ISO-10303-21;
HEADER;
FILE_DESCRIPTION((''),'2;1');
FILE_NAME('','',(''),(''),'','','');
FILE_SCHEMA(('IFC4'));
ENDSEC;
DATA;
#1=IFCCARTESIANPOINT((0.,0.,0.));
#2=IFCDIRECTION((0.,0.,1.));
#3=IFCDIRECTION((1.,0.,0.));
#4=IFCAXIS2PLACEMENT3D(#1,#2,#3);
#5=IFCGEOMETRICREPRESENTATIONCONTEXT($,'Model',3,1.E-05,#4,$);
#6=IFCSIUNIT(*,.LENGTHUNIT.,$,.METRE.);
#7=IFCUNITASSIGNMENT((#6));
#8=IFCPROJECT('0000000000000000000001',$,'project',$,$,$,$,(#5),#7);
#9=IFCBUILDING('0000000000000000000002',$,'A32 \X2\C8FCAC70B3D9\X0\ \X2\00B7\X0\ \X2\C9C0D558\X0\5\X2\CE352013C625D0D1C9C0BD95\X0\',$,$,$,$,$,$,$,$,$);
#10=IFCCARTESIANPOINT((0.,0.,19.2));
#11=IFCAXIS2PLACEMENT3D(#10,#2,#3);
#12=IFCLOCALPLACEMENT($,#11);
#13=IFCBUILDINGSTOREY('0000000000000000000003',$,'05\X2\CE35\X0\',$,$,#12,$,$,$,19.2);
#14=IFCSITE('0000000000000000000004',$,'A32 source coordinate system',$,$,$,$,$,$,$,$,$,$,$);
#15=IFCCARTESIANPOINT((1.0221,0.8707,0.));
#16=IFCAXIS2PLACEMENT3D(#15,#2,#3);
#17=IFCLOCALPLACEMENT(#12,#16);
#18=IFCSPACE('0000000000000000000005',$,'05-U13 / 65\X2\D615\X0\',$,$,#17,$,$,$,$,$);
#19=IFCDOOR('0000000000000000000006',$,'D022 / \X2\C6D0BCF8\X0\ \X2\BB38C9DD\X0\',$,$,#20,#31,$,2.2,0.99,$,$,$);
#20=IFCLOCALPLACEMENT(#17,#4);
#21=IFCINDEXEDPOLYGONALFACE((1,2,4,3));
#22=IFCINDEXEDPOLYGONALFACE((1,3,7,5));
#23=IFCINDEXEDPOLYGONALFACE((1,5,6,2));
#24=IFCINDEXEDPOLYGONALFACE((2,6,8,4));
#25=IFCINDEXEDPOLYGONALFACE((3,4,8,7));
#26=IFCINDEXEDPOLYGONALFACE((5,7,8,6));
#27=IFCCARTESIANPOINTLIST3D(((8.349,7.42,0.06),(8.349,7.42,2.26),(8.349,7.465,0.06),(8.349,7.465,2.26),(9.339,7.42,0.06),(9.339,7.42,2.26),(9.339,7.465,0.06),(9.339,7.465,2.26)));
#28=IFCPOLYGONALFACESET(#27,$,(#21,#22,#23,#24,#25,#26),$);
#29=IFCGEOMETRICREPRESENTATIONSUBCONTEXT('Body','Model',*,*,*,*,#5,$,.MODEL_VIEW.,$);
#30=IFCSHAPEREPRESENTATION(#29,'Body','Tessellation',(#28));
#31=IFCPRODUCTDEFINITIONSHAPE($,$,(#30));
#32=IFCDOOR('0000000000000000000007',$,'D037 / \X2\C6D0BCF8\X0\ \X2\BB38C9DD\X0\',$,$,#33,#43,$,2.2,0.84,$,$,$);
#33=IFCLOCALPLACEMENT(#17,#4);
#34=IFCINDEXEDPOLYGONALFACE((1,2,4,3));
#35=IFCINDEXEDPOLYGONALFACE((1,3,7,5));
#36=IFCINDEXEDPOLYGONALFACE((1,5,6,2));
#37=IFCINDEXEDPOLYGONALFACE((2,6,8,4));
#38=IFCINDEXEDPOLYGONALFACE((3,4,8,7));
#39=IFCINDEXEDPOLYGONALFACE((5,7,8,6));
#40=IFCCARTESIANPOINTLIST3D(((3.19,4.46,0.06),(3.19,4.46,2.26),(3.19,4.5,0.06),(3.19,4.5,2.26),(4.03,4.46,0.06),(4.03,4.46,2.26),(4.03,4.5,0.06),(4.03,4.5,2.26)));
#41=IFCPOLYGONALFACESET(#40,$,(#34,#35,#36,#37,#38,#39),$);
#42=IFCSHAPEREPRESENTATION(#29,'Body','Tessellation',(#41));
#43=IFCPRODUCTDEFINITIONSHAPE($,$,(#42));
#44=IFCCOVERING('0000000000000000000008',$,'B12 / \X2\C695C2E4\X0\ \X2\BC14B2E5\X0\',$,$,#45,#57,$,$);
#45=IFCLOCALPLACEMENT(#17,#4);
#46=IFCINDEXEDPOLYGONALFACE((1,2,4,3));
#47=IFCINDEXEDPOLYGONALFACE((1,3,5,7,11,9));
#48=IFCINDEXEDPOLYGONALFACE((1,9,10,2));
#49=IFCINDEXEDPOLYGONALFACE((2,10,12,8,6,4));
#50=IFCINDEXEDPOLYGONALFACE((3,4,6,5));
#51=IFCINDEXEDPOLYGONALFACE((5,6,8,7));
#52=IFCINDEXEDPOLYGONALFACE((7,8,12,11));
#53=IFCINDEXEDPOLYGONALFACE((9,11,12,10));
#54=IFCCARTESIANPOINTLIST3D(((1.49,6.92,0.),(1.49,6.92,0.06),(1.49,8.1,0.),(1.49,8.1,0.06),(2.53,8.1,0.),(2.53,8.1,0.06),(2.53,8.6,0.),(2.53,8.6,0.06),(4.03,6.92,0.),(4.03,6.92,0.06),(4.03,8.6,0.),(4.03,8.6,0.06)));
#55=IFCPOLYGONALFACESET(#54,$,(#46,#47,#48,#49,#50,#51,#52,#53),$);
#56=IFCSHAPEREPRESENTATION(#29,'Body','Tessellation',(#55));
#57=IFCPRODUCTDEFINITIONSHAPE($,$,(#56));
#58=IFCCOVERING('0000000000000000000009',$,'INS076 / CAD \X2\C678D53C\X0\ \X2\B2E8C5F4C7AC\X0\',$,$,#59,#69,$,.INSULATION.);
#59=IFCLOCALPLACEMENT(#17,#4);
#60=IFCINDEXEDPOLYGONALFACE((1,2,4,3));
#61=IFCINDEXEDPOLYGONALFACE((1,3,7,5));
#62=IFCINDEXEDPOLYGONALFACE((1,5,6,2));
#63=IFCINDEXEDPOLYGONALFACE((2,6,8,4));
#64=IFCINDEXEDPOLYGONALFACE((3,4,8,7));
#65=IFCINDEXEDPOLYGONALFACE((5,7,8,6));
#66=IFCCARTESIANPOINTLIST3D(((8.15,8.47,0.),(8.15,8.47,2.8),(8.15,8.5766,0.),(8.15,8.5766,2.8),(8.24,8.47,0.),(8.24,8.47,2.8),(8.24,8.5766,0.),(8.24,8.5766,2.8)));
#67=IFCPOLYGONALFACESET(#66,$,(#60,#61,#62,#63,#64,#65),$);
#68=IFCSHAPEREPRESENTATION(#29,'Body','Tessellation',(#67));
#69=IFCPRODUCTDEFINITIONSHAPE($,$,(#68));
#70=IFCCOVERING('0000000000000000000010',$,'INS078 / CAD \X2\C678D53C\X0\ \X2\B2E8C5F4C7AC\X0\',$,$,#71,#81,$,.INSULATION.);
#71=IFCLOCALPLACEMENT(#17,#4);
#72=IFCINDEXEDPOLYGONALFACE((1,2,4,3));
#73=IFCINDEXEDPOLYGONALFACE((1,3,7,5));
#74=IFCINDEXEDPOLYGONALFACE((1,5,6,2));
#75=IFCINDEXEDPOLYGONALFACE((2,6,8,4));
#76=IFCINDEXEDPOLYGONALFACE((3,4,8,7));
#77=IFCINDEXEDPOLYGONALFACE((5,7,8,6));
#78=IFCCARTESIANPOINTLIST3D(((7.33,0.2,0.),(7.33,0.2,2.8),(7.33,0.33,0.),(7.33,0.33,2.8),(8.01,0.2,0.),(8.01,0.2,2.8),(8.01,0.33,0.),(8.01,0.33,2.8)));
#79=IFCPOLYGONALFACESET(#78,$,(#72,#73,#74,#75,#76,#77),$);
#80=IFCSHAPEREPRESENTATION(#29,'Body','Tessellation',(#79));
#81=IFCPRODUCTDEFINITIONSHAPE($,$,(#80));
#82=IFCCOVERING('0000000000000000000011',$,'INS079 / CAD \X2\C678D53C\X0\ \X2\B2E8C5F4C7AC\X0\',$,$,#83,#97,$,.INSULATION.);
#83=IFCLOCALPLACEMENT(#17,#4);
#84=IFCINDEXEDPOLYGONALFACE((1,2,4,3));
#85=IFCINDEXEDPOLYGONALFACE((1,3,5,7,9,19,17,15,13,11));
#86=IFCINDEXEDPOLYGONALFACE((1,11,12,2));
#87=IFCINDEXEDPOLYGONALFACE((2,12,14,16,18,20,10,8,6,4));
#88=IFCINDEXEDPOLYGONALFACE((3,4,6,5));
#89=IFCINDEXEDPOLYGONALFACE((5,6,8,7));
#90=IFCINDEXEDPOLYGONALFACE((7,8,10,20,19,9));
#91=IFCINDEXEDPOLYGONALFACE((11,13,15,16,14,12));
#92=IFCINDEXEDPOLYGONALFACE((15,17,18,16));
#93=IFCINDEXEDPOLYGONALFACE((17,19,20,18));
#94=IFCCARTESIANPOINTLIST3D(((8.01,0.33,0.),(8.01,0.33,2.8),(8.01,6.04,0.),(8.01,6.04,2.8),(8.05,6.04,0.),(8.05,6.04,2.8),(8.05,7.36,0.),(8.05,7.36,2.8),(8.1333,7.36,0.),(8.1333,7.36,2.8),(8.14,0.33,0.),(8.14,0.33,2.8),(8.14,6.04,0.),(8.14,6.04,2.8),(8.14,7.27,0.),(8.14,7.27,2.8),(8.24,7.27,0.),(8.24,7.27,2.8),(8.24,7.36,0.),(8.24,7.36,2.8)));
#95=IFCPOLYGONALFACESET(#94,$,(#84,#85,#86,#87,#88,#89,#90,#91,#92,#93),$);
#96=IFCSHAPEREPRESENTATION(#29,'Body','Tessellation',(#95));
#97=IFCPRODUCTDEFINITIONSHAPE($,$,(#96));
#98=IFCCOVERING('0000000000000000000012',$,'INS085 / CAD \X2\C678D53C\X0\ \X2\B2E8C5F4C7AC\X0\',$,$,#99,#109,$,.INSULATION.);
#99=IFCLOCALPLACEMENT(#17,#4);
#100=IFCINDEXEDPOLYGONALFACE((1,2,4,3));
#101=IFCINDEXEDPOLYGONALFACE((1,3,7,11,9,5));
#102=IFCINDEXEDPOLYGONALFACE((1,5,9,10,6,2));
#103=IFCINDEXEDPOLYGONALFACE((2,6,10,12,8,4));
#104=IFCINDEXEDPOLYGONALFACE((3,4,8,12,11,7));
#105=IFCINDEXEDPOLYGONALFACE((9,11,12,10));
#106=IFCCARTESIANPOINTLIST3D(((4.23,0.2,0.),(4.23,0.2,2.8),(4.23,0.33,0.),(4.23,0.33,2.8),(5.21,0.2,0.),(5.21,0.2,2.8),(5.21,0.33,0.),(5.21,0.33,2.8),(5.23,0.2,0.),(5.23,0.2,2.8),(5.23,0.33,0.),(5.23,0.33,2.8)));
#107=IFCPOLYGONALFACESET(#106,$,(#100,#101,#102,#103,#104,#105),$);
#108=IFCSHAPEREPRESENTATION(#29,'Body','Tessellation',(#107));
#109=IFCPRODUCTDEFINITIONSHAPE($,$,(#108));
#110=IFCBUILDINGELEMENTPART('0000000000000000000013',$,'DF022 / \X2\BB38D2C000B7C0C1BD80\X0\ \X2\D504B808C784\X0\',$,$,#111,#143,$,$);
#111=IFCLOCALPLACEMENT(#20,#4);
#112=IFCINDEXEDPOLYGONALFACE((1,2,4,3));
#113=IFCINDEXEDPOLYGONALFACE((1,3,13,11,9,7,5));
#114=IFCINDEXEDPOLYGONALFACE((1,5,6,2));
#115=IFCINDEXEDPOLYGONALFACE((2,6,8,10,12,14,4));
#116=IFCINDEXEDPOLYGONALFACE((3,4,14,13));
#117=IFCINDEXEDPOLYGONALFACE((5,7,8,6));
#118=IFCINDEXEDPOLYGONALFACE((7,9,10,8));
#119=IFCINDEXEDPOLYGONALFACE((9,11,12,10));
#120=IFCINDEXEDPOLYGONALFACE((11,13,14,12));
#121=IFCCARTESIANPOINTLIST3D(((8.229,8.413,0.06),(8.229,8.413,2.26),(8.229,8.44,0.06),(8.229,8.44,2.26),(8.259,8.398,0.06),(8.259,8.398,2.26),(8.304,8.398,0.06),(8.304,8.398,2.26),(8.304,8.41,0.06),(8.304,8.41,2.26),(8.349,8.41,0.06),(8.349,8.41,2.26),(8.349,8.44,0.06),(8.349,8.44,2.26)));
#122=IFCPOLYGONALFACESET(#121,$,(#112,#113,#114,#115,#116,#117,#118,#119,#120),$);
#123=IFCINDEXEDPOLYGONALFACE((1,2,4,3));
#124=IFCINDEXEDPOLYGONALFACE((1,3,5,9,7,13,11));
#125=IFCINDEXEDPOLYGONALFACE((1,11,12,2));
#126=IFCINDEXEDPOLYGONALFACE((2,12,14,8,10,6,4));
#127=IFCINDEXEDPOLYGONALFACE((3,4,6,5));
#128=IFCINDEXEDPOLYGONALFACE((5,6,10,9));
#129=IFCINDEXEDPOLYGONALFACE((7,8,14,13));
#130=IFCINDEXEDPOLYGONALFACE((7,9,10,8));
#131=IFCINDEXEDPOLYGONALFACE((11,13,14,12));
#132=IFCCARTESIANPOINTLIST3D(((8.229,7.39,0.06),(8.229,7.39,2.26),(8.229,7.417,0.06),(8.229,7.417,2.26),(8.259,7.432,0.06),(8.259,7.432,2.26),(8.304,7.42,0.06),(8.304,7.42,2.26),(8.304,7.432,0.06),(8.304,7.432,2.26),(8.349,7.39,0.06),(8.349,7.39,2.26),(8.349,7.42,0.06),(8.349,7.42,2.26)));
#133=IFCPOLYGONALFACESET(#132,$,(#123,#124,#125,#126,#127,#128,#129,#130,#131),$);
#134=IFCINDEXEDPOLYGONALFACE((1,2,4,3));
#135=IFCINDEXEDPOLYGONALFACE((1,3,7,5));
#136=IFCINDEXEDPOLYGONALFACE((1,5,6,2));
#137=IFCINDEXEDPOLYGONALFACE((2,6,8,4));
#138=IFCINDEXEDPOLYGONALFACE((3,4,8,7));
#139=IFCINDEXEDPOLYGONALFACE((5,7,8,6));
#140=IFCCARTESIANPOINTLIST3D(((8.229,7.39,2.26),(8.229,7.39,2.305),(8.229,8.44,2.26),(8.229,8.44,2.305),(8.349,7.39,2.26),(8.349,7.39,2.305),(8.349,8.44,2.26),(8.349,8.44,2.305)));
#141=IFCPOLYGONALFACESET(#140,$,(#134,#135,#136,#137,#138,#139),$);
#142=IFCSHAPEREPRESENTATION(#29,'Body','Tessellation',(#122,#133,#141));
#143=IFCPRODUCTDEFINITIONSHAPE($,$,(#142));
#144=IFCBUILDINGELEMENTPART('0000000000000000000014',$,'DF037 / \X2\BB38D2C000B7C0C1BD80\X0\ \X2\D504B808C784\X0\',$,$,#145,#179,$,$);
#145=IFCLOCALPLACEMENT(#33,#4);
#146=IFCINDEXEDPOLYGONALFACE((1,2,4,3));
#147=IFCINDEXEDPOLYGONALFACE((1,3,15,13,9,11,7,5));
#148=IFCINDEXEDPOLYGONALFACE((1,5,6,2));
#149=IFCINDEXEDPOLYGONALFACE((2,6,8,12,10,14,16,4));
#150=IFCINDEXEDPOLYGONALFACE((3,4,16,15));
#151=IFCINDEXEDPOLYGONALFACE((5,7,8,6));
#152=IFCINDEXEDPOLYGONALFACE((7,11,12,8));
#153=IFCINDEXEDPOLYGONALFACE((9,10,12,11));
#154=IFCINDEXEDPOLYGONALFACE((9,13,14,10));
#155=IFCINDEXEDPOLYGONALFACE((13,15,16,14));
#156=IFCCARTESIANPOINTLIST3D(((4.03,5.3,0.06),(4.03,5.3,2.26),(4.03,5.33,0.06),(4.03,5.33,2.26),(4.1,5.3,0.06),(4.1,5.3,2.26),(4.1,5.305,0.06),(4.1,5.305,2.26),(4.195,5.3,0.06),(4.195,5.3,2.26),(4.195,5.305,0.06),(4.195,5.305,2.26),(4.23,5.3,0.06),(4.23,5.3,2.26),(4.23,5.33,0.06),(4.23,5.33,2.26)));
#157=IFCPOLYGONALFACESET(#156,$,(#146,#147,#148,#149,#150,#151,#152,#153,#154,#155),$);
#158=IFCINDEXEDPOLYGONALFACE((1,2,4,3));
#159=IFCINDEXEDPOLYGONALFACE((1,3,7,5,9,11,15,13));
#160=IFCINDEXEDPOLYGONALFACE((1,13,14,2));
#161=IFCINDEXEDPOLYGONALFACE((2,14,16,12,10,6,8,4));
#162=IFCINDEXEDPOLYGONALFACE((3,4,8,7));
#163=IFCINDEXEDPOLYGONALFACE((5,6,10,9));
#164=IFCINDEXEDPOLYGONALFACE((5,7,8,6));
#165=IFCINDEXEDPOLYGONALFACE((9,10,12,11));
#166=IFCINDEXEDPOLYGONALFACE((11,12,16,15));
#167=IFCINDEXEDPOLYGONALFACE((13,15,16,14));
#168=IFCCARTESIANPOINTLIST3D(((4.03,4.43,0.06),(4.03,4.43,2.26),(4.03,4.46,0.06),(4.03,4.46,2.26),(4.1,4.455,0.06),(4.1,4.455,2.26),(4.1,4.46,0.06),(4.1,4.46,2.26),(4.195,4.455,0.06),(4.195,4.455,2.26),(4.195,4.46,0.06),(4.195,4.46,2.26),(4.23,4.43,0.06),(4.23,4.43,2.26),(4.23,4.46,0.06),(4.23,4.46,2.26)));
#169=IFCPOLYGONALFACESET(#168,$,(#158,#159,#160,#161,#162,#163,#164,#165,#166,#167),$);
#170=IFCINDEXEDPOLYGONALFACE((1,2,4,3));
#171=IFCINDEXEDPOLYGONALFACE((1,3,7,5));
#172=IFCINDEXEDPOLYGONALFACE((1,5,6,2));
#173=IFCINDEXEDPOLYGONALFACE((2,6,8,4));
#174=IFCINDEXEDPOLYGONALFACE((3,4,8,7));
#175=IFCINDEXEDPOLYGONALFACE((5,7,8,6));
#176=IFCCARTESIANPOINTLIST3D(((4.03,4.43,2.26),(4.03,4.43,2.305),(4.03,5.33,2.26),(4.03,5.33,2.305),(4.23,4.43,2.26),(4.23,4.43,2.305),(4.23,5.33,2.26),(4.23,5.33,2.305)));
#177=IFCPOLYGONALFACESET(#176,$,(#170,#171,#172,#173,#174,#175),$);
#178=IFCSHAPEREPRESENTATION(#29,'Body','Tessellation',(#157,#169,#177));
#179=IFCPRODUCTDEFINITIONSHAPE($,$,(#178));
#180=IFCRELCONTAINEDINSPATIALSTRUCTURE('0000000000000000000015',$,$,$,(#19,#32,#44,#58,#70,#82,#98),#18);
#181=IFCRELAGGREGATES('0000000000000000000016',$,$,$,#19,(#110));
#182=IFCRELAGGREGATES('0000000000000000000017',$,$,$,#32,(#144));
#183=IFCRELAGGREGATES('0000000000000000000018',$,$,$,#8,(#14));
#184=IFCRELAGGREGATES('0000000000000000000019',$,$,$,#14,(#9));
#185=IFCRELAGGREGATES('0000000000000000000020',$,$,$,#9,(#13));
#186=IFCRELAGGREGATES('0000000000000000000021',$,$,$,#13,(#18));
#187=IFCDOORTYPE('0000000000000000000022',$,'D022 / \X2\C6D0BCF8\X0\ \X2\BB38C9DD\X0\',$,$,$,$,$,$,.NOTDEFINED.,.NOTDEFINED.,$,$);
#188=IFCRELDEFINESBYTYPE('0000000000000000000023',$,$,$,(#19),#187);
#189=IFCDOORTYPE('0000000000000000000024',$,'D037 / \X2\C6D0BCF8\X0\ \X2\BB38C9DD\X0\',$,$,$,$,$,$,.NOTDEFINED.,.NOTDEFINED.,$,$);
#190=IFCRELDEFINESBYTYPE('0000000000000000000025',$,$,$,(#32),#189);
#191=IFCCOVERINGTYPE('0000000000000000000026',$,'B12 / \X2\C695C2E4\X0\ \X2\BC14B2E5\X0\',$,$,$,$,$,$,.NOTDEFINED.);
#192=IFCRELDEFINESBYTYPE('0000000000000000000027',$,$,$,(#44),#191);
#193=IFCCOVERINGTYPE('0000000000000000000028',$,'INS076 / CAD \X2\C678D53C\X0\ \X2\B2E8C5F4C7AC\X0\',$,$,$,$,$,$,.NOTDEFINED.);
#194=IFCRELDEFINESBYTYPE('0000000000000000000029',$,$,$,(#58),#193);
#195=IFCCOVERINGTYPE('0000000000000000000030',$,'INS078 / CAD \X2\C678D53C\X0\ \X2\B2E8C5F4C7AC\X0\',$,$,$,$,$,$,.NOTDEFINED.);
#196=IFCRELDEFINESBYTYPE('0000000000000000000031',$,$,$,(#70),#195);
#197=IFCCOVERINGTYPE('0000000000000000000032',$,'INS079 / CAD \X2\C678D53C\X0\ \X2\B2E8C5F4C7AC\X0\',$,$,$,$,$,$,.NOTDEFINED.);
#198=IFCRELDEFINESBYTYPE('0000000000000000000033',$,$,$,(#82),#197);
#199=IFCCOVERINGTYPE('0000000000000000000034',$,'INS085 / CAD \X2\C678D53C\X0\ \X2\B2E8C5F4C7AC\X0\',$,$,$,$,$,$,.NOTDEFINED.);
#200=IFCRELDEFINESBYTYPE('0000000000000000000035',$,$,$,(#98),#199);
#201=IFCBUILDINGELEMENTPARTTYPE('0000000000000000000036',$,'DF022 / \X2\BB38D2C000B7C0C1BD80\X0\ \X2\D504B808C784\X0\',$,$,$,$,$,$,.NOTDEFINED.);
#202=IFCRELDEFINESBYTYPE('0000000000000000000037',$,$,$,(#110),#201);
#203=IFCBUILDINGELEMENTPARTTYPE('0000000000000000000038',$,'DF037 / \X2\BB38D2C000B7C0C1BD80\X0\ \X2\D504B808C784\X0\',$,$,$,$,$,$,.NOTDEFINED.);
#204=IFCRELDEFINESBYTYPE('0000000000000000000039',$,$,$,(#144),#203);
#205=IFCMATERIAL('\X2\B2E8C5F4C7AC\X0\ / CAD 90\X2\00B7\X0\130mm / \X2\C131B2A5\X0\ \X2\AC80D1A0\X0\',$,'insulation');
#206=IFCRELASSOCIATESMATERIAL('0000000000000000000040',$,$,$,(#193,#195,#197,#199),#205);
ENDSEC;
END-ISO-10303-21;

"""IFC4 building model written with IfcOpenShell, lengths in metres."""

from ifc_helpers import new_model, si_unit, frame, origin, origin_with_axes, place, context, subcontext, project, spatial, polyline, outline, extrude, source, transform, mapped, material, type_object, type_shapes, element, aggregate, save


model = new_model("IFC4")

# Units and contexts
model_context = context("Model", 3, precision=1e-05, world=origin_with_axes())
body_context = subcontext(model_context, "Body", "Model", "MODEL_VIEW")
ifc_project = project(units=[si_unit("LENGTHUNIT", "METRE")], contexts=[model_context])

# Site, building, storey
site = spatial("IfcSite", under=ifc_project, Name="A32 source coordinate system")
building = spatial("IfcBuilding", under=site, Name="A32 주거동 · 지하5층–옥탑지붕")
storey_placement = place(None, frame((0.0, 0.0, 19.2), z_axis=(0.0, 0.0, 1.0), x_axis=(1.0, 0.0, 0.0)))
storey = spatial("IfcBuildingStorey", under=building, at=storey_placement, Name="05층", Elevation=19.2)

# Shared definitions
space_placement = place(storey_placement, frame((1.0221, 0.8707, 0.0), z_axis=(0.0, 0.0, 1.0), x_axis=(1.0, 0.0, 0.0)))
space = spatial("IfcSpace", under=storey, at=space_placement, Name="05-U13 / 65형")

# Doors
door_type_1 = type_object("IfcDoorType", Name="D022 / 원본 문짝", OperationType="NOTDEFINED", PredefinedType="NOTDEFINED")
shared_shape_1 = source(origin(), body_context, "Body", "SweptSolid", [
    extrude(outline(polyline([(9.339, 7.465), (9.339, 7.42), (8.349, 7.42), (8.349, 7.465), (9.339, 7.465)])), frame((0.0, 0.0, 0.06)), (0.0, 0.0, 1.0), 2.2),
])
type_shapes(door_type_1, [shared_shape_1])
door_1_placement = place(space_placement, origin_with_axes())
door_1 = element("IfcDoor", 1, at=door_1_placement, inside=space, type_object=door_type_1, Name="D022 / 원본 문짝", OverallHeight=2.2, OverallWidth=0.99, context=body_context, shape_type="MappedRepresentation", body=[
    mapped(shared_shape_1, transform((0.0, 0.0, 0.0), scale=1.0)),
])
door_type_2 = type_object("IfcDoorType", Name="D037 / 원본 문짝", OperationType="NOTDEFINED", PredefinedType="NOTDEFINED")
shared_shape_2 = source(origin(), body_context, "Body", "SweptSolid", [
    extrude(outline(polyline([(4.03, 4.46), (3.19, 4.46), (3.19, 4.5), (4.03, 4.5), (4.03, 4.46)])), frame((0.0, 0.0, 0.06)), (0.0, 0.0, 1.0), 2.2),
])
type_shapes(door_type_2, [shared_shape_2])
door_2_placement = place(space_placement, origin_with_axes())
door_2 = element("IfcDoor", 2, at=door_2_placement, inside=space, type_object=door_type_2, Name="D037 / 원본 문짝", OverallHeight=2.2, OverallWidth=0.84, context=body_context, shape_type="MappedRepresentation", body=[
    mapped(shared_shape_2, transform((0.0, 0.0, 0.0), scale=1.0)),
])

# Coverings
covering_type_1 = type_object("IfcCoveringType", Name="B12 / 욕실 바닥", PredefinedType="NOTDEFINED")
shared_shape_3 = source(origin(), body_context, "Body", "SweptSolid", [
    extrude(outline(polyline([(2.53, 8.6), (4.03, 8.6), (4.03, 6.92), (1.49, 6.92), (1.49, 8.1), (2.53, 8.1), (2.53, 8.6)])), origin(), (0.0, 0.0, 1.0), 0.06),
])
type_shapes(covering_type_1, [shared_shape_3])
covering_1_placement = place(space_placement, origin_with_axes())
element("IfcCovering", 3, at=covering_1_placement, inside=space, type_object=covering_type_1, Name="B12 / 욕실 바닥", context=body_context, shape_type="MappedRepresentation", body=[
    mapped(shared_shape_3, transform((0.0, 0.0, 0.0), scale=1.0)),
])
ifc_material = material(Name="단열재 / CAD 90·130mm / 성능 검토", Category="insulation")
covering_type_2 = type_object("IfcCoveringType", Name="INS076 / CAD 외피 단열재", PredefinedType="NOTDEFINED", material=ifc_material)
shared_shape_4 = source(origin(), body_context, "Body", "SweptSolid", [
    extrude(outline(polyline([(8.24, 8.5766), (8.24, 8.47), (8.15, 8.47), (8.15, 8.5766), (8.24, 8.5766)])), origin(), (0.0, 0.0, 1.0), 2.8),
])
type_shapes(covering_type_2, [shared_shape_4])
covering_2_placement = place(space_placement, origin_with_axes())
element("IfcCovering", 4, at=covering_2_placement, inside=space, type_object=covering_type_2, Name="INS076 / CAD 외피 단열재", PredefinedType="INSULATION", context=body_context, shape_type="MappedRepresentation", body=[
    mapped(shared_shape_4, transform((0.0, 0.0, 0.0), scale=1.0)),
])
covering_type_3 = type_object("IfcCoveringType", Name="INS078 / CAD 외피 단열재", PredefinedType="NOTDEFINED", material=ifc_material)
shared_shape_5 = source(origin(), body_context, "Body", "SweptSolid", [
    extrude(outline(polyline([(8.01, 0.2), (7.33, 0.2), (7.33, 0.33), (8.01, 0.33), (8.01, 0.2)])), origin(), (0.0, 0.0, 1.0), 2.8),
])
type_shapes(covering_type_3, [shared_shape_5])
covering_3_placement = place(space_placement, origin_with_axes())
element("IfcCovering", 5, at=covering_3_placement, inside=space, type_object=covering_type_3, Name="INS078 / CAD 외피 단열재", PredefinedType="INSULATION", context=body_context, shape_type="MappedRepresentation", body=[
    mapped(shared_shape_5, transform((0.0, 0.0, 0.0), scale=1.0)),
])
covering_type_4 = type_object("IfcCoveringType", Name="INS079 / CAD 외피 단열재", PredefinedType="NOTDEFINED", material=ifc_material)
shared_shape_6 = source(origin(), body_context, "Body", "SweptSolid", [
    extrude(outline(polyline([(8.24, 7.27), (8.14, 7.27), (8.14, 6.04), (8.14, 0.33), (8.01, 0.33), (8.01, 6.04), (8.05, 6.04), (8.05, 7.36), (8.1333, 7.36), (8.24, 7.36), (8.24, 7.27)])), origin(), (0.0, 0.0, 1.0), 2.8),
])
type_shapes(covering_type_4, [shared_shape_6])
covering_4_placement = place(space_placement, origin_with_axes())
element("IfcCovering", 6, at=covering_4_placement, inside=space, type_object=covering_type_4, Name="INS079 / CAD 외피 단열재", PredefinedType="INSULATION", context=body_context, shape_type="MappedRepresentation", body=[
    mapped(shared_shape_6, transform((0.0, 0.0, 0.0), scale=1.0)),
])
covering_type_5 = type_object("IfcCoveringType", Name="INS085 / CAD 외피 단열재", PredefinedType="NOTDEFINED", material=ifc_material)
shared_shape_7 = source(origin(), body_context, "Body", "SweptSolid", [
    extrude(outline(polyline([(4.23, 0.2), (4.23, 0.33), (5.21, 0.33), (5.23, 0.33), (5.23, 0.2), (5.21, 0.2), (4.23, 0.2)])), origin(), (0.0, 0.0, 1.0), 2.8),
])
type_shapes(covering_type_5, [shared_shape_7])
covering_5_placement = place(space_placement, origin_with_axes())
element("IfcCovering", 7, at=covering_5_placement, inside=space, type_object=covering_type_5, Name="INS085 / CAD 외피 단열재", PredefinedType="INSULATION", context=body_context, shape_type="MappedRepresentation", body=[
    mapped(shared_shape_7, transform((0.0, 0.0, 0.0), scale=1.0)),
])

# Building element parts
building_element_part_type_1 = type_object("IfcBuildingElementPartType", Name="DF022 / 문틀·상부 프레임", PredefinedType="NOTDEFINED")
shared_shape_8 = source(origin(), body_context, "Body", "SweptSolid", [
    extrude(outline(polyline([(8.349, 8.41), (8.304, 8.41), (8.304, 8.398), (8.259, 8.398), (8.229, 8.413), (8.229, 8.44), (8.349, 8.44), (8.349, 8.41)])), frame((0.0, 0.0, 0.06)), (0.0, 0.0, 1.0), 2.2),
    extrude(outline(polyline([(8.229, 7.39), (8.229, 7.417), (8.259, 7.432), (8.304, 7.432), (8.304, 7.42), (8.349, 7.42), (8.349, 7.39), (8.229, 7.39)])), frame((0.0, 0.0, 0.06)), (0.0, 0.0, 1.0), 2.2),
    extrude(outline(polyline([(8.229, 7.39), (8.229, 8.44), (8.349, 8.44), (8.349, 7.39), (8.229, 7.39)])), frame((0.0, 0.0, 2.26)), (0.0, 0.0, 1.0), 0.045),
])
type_shapes(building_element_part_type_1, [shared_shape_8])
building_element_part_1_placement = place(door_1_placement, origin_with_axes())
building_element_part_1 = element("IfcBuildingElementPart", 8, at=building_element_part_1_placement, type_object=building_element_part_type_1, Name="DF022 / 문틀·상부 프레임", context=body_context, shape_type="MappedRepresentation", body=[
    mapped(shared_shape_8, transform((0.0, 0.0, 0.0), scale=1.0)),
])
aggregate(door_1, [building_element_part_1])
building_element_part_type_2 = type_object("IfcBuildingElementPartType", Name="DF037 / 문틀·상부 프레임", PredefinedType="NOTDEFINED")
shared_shape_9 = source(origin(), body_context, "Body", "SweptSolid", [
    extrude(outline(polyline([(4.23, 5.33), (4.23, 5.3), (4.195, 5.3), (4.195, 5.305), (4.1, 5.305), (4.1, 5.3), (4.03, 5.3), (4.03, 5.33), (4.23, 5.33)])), frame((0.0, 0.0, 0.06)), (0.0, 0.0, 1.0), 2.2),
    extrude(outline(polyline([(4.03, 4.46), (4.1, 4.46), (4.1, 4.455), (4.195, 4.455), (4.195, 4.46), (4.23, 4.46), (4.23, 4.43), (4.03, 4.43), (4.03, 4.46)])), frame((0.0, 0.0, 0.06)), (0.0, 0.0, 1.0), 2.2),
    extrude(outline(polyline([(4.03, 4.43), (4.03, 5.33), (4.23, 5.33), (4.23, 4.43), (4.03, 4.43)])), frame((0.0, 0.0, 2.26)), (0.0, 0.0, 1.0), 0.045),
])
type_shapes(building_element_part_type_2, [shared_shape_9])
building_element_part_2_placement = place(door_2_placement, origin_with_axes())
building_element_part_2 = element("IfcBuildingElementPart", 9, at=building_element_part_2_placement, type_object=building_element_part_type_2, Name="DF037 / 문틀·상부 프레임", context=body_context, shape_type="MappedRepresentation", body=[
    mapped(shared_shape_9, transform((0.0, 0.0, 0.0), scale=1.0)),
])
aggregate(door_2, [building_element_part_2])

save(model, "model.ifc")
